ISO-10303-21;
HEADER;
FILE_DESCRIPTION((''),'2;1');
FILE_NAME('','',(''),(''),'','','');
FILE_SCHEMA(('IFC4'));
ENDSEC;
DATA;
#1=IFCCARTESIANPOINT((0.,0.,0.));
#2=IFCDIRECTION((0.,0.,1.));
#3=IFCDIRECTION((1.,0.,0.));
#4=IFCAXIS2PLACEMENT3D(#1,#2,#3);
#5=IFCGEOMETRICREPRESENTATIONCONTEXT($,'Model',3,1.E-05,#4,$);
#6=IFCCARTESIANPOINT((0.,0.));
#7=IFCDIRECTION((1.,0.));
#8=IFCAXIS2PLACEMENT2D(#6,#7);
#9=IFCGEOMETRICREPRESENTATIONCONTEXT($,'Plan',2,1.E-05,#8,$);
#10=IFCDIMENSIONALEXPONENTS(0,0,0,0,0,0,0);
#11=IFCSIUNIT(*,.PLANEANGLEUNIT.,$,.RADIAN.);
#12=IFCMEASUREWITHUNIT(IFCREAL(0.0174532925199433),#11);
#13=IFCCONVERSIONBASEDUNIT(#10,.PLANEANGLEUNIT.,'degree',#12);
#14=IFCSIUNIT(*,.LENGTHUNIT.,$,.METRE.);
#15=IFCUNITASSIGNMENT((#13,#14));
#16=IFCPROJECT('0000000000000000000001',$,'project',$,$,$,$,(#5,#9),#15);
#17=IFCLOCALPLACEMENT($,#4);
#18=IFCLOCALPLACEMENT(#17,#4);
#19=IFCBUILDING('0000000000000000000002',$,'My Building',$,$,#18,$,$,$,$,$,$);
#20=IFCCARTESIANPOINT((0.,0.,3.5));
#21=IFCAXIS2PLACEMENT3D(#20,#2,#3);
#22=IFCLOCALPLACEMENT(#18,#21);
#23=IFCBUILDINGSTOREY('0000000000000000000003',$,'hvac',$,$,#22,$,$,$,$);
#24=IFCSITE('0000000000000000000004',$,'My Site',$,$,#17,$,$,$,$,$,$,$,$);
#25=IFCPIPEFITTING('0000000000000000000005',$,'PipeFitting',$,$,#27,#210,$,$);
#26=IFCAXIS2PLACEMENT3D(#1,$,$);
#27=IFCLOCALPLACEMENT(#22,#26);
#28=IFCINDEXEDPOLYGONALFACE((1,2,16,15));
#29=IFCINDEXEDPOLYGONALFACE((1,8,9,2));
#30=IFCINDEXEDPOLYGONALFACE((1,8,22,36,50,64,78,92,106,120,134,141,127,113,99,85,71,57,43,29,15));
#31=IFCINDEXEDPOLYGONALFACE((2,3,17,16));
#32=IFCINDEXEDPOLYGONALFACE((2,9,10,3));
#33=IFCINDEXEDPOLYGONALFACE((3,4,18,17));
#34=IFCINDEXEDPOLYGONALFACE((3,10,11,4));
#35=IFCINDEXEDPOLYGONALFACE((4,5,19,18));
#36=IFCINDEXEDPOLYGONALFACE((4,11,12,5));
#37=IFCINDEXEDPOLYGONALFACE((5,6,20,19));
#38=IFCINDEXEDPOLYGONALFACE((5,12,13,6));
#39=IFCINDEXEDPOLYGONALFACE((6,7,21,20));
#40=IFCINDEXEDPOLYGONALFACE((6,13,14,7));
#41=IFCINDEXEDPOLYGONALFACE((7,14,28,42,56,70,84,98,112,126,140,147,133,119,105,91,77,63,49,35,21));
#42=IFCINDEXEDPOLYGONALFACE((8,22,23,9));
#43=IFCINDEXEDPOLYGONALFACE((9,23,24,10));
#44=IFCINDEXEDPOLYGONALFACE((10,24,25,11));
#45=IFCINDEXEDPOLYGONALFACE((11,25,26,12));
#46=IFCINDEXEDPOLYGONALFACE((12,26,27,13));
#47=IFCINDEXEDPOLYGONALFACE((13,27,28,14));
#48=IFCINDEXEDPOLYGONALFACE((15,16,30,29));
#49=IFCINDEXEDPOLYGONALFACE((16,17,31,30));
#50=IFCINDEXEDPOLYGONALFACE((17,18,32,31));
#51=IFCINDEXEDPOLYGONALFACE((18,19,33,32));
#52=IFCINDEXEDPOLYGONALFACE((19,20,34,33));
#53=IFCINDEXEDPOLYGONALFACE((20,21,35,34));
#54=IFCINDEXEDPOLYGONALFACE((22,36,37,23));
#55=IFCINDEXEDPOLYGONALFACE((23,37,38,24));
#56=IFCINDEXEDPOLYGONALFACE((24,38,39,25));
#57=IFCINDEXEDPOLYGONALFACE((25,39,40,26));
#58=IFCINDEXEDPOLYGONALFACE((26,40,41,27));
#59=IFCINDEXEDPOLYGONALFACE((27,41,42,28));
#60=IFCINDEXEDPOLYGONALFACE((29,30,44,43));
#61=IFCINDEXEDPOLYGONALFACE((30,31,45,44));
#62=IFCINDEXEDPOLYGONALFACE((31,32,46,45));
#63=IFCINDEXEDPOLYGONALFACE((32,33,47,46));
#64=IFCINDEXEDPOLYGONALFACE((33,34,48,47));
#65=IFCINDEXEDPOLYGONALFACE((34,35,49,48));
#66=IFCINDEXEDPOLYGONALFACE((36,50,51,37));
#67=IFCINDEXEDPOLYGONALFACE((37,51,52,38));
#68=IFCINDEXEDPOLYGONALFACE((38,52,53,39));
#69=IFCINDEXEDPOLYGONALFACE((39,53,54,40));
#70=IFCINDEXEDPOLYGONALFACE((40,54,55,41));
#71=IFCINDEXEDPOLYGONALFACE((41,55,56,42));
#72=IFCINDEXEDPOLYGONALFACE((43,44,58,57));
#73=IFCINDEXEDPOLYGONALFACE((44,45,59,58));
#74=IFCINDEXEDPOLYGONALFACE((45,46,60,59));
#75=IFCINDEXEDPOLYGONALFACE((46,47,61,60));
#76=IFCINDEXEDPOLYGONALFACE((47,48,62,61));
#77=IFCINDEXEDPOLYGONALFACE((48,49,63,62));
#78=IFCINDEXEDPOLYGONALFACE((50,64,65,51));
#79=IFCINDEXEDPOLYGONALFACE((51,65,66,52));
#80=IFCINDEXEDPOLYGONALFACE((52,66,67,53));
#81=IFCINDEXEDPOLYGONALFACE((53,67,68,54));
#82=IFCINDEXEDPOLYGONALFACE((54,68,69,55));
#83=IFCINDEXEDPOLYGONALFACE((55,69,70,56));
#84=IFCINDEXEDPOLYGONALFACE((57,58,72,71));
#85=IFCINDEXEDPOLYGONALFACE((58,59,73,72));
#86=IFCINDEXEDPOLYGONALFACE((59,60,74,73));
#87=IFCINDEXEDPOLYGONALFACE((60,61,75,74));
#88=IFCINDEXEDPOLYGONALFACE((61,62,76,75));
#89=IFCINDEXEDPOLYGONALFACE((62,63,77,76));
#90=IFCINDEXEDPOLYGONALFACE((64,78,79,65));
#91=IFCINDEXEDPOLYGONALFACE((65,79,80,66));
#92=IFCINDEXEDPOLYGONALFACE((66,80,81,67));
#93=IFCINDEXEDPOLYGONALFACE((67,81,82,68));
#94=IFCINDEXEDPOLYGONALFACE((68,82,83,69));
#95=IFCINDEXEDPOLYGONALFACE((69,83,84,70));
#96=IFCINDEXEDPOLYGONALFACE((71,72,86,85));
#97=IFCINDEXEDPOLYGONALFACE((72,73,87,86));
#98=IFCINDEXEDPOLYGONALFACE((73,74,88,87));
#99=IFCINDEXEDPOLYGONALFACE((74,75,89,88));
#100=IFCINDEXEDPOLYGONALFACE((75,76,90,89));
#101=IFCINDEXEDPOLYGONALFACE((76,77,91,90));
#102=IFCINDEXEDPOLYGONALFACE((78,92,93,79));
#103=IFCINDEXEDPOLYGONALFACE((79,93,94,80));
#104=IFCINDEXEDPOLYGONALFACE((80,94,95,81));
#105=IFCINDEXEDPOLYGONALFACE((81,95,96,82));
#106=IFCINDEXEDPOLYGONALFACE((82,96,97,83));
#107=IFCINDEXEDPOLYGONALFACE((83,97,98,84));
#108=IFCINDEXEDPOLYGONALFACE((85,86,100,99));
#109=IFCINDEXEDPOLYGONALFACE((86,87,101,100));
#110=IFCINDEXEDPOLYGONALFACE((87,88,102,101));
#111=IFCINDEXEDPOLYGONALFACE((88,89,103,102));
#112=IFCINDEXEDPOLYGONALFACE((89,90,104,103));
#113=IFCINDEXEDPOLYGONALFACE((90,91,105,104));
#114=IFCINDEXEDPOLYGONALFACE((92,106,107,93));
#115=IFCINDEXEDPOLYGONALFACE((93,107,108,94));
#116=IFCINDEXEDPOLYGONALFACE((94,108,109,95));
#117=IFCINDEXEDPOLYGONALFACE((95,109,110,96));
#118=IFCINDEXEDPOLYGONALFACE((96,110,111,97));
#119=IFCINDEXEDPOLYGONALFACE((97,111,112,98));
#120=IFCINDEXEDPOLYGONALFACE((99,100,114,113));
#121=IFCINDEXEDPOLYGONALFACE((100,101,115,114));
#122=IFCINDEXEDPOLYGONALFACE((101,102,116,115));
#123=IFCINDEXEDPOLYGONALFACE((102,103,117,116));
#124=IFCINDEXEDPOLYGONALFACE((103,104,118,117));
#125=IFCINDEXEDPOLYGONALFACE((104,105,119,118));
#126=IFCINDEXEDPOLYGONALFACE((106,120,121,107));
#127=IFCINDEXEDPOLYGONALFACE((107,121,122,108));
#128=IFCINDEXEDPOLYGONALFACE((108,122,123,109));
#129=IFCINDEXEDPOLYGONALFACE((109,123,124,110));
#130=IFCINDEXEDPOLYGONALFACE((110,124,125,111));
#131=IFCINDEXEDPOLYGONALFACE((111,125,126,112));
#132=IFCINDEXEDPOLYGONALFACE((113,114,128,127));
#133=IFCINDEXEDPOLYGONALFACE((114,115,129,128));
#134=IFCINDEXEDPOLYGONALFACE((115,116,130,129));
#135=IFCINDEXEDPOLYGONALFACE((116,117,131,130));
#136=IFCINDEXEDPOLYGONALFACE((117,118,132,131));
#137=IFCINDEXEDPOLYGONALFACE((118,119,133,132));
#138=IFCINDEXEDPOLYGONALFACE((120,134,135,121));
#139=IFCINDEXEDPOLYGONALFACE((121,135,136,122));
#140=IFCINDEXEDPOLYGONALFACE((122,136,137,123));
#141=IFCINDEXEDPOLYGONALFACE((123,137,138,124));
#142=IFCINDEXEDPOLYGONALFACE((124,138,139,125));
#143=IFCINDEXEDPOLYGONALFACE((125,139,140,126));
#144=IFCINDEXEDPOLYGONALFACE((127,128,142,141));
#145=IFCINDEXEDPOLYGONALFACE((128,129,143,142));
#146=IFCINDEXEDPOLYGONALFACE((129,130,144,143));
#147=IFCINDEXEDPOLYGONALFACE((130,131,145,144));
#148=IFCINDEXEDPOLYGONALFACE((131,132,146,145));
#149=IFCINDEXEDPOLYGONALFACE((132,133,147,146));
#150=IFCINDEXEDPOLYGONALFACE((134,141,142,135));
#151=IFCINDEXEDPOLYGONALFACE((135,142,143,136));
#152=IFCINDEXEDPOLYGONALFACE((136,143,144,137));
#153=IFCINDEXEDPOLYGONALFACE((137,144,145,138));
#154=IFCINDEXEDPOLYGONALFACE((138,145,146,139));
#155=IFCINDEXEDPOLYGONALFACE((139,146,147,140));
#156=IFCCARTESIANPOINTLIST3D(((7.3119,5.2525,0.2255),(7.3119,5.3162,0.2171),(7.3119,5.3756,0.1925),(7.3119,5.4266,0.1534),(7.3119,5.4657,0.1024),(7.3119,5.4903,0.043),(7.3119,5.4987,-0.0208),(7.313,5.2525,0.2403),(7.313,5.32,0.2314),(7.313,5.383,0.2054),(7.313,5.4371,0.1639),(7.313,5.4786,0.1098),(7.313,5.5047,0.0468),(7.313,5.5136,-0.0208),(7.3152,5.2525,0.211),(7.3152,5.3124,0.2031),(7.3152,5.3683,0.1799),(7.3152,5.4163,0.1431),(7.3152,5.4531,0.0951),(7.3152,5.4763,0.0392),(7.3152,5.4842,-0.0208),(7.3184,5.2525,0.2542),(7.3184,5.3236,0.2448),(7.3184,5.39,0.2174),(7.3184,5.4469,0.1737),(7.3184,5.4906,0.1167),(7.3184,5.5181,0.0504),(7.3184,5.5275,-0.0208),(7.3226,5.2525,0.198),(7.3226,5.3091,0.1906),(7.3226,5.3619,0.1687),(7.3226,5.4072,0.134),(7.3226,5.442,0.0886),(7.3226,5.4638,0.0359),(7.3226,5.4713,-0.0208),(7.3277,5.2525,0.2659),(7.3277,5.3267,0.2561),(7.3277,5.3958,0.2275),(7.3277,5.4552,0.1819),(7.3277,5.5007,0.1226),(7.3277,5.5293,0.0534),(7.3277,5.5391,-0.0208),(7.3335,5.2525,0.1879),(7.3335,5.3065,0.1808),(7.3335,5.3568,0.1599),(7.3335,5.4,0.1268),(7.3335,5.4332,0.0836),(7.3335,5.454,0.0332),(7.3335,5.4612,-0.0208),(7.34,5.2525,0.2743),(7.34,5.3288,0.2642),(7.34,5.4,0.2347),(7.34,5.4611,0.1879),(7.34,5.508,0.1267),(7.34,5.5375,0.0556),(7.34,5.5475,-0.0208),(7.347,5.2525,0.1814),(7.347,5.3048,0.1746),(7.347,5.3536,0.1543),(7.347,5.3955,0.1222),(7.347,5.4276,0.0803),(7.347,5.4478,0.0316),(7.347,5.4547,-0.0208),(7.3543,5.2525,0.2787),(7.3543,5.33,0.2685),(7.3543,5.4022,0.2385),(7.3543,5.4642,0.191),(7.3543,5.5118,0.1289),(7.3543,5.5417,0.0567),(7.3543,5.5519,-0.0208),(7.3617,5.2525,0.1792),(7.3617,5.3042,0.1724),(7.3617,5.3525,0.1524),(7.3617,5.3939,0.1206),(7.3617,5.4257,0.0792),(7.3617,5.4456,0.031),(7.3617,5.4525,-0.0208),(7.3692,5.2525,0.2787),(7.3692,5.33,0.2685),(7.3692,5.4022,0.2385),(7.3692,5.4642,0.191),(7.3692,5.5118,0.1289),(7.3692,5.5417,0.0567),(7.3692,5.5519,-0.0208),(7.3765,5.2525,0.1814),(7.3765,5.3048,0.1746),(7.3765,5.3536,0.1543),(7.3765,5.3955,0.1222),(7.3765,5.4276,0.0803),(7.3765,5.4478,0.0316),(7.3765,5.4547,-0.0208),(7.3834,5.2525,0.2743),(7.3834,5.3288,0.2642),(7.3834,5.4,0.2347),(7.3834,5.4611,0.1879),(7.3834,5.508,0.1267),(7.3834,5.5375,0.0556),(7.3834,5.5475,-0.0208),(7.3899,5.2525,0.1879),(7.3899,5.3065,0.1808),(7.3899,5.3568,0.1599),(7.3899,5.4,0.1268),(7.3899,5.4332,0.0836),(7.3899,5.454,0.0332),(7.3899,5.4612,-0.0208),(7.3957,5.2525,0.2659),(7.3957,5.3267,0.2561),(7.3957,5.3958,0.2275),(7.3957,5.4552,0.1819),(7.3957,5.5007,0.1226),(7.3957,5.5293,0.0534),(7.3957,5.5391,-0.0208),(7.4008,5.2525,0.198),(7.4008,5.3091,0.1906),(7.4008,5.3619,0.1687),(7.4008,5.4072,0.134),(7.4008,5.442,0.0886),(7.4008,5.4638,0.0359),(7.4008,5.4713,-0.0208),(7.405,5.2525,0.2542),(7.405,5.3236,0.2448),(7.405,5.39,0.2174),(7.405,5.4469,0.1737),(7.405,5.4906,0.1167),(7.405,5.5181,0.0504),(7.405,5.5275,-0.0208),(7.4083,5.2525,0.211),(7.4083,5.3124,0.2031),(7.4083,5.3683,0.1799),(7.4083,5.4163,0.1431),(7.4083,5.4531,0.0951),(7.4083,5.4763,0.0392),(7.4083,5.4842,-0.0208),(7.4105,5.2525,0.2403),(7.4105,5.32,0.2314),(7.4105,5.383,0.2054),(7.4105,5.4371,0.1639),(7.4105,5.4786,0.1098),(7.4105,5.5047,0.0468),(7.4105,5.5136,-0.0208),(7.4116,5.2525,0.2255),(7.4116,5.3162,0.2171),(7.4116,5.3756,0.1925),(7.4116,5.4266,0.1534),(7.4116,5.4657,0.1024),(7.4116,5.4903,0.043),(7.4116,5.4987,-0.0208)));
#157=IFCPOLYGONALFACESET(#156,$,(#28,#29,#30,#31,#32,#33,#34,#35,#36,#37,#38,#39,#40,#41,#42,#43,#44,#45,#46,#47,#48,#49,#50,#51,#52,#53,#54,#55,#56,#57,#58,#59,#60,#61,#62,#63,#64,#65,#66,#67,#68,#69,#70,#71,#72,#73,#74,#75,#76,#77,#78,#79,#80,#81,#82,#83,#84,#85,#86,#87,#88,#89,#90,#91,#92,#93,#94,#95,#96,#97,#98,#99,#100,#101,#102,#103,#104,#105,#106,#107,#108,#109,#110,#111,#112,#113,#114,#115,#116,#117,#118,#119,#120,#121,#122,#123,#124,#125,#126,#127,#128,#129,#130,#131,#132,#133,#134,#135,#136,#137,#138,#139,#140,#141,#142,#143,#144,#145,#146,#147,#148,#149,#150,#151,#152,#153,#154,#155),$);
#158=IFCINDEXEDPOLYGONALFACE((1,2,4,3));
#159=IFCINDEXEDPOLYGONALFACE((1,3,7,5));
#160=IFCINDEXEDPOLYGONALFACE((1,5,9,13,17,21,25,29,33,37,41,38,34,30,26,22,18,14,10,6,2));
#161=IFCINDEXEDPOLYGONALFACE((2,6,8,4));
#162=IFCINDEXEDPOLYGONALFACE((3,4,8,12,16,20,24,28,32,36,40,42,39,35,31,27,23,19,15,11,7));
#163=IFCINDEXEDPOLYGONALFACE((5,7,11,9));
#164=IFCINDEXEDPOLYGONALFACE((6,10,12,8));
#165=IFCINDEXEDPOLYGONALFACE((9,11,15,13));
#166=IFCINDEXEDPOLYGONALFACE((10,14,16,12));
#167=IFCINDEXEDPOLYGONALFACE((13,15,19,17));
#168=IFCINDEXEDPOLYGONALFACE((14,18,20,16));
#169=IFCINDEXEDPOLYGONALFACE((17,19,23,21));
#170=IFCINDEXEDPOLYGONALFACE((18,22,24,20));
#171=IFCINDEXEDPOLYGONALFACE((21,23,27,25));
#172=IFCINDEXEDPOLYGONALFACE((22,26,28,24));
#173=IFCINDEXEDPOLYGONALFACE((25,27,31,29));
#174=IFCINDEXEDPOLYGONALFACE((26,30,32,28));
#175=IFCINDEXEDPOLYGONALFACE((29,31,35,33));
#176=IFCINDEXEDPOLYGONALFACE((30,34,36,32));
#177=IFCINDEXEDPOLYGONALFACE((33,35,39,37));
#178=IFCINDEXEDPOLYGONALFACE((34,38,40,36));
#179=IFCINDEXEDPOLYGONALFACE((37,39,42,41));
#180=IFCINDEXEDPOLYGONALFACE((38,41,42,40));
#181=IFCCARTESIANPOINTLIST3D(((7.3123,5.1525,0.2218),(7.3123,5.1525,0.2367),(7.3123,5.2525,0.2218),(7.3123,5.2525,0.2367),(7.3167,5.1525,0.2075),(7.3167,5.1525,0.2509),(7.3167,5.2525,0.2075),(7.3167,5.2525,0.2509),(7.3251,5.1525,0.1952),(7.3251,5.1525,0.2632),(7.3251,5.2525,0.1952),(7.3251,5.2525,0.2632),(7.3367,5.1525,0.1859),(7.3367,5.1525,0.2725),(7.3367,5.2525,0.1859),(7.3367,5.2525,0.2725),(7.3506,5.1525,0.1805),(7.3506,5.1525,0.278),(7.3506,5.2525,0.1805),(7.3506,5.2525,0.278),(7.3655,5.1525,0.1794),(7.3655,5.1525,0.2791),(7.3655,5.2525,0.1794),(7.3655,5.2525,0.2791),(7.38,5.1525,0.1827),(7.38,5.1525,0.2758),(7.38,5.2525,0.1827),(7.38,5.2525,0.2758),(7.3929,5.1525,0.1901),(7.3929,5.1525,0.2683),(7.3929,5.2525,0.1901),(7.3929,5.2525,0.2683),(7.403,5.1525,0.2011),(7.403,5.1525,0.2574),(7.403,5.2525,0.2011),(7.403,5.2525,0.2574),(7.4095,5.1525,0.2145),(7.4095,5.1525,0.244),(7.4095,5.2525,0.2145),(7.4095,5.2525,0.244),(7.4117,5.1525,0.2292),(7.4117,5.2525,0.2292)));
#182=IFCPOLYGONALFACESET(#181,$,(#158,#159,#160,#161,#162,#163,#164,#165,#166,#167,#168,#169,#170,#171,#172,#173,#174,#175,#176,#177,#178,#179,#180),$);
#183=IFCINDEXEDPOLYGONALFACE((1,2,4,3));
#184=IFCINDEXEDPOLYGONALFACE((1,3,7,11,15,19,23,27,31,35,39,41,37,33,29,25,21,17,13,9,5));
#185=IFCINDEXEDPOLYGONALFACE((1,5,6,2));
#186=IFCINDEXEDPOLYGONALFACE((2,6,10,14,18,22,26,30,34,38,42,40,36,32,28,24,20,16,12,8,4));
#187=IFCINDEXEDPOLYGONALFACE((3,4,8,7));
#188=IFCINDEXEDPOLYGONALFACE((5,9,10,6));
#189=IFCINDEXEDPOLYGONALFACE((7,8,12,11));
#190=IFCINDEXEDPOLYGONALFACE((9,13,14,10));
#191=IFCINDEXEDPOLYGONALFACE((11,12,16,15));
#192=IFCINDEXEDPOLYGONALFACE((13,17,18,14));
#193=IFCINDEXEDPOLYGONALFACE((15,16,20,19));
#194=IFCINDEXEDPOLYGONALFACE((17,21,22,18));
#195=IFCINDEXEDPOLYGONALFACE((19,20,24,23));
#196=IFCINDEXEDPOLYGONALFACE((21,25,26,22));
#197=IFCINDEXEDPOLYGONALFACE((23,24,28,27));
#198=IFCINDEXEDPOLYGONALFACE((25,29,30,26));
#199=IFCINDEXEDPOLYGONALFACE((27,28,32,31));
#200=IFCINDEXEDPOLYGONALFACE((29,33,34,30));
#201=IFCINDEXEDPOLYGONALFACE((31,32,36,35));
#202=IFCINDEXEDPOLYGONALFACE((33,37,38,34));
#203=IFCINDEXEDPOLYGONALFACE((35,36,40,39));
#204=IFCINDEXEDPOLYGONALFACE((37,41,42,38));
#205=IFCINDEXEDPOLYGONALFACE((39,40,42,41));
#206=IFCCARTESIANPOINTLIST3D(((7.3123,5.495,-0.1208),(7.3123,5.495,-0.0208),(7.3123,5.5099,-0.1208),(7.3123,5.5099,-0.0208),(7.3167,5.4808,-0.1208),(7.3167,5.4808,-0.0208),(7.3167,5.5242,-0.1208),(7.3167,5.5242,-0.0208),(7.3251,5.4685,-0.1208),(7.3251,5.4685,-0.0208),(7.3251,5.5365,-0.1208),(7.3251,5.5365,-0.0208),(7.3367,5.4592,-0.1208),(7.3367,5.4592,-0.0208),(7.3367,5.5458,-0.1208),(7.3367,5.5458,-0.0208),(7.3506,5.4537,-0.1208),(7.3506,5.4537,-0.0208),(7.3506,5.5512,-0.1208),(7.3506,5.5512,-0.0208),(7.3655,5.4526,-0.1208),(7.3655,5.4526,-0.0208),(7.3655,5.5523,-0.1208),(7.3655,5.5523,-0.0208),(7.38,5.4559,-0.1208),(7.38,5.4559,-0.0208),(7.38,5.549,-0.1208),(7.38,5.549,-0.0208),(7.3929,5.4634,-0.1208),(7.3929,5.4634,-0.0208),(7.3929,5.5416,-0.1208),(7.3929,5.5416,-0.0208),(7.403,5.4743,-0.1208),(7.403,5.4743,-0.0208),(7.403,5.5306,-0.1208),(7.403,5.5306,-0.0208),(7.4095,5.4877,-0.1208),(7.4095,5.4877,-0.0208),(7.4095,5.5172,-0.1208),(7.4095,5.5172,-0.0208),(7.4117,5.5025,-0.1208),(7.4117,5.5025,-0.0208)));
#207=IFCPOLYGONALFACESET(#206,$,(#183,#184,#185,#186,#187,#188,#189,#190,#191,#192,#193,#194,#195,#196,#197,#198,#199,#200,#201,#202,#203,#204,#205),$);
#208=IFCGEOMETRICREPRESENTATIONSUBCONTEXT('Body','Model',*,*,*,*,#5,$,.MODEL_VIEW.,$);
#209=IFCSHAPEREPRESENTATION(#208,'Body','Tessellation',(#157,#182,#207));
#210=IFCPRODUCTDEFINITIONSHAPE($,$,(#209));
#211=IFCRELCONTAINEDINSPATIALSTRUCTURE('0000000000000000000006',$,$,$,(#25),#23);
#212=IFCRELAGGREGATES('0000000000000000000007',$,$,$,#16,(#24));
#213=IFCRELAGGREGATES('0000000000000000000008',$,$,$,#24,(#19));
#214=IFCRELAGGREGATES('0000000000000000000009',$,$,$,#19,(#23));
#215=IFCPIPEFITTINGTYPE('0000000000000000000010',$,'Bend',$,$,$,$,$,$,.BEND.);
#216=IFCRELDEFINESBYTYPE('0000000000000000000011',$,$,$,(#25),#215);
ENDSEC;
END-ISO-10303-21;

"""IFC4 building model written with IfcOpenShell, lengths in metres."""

from ifc_helpers import new_model, entity, si_unit, converted_unit, frame, origin_with_axes, origin_2d_with_axis, place, context, subcontext, project, spatial, circle, extrude, source, transform, mapped, type_object, type_shapes, element, save


model = new_model("IFC4")

# Units and contexts
model_context = context("Model", 3, precision=1e-05, world=origin_with_axes())
plan_context = context("Plan", 2, precision=1e-05, world=origin_2d_with_axis())
body_context_1 = subcontext(model_context, "Body", "Model", "MODEL_VIEW")
ifc_project = project(units=[converted_unit("PLANEANGLEUNIT", "degree", entity("IfcReal", 0.0174532925199433), si_unit("PLANEANGLEUNIT", "RADIAN"), dimensions=[0, 0, 0, 0, 0, 0, 0]), si_unit("LENGTHUNIT", "METRE")], contexts=[model_context, plan_context])

# Site, building, storey
site_placement = place(None, origin_with_axes())
site = spatial("IfcSite", under=ifc_project, at=site_placement, Name="My Site")
building_placement = place(site_placement, origin_with_axes())
building = spatial("IfcBuilding", under=site, at=building_placement, Name="My Building")
storey_placement = place(building_placement, frame((0.0, 0.0, 3.5), z_axis=(0.0, 0.0, 1.0), x_axis=(1.0, 0.0, 0.0)))
storey = spatial("IfcBuildingStorey", under=building, at=storey_placement, Name="hvac")

# Pipe fitting
pipe_fitting_type = type_object("IfcPipeFittingType", Name="Bend", PredefinedType="BEND")
shared_shape_1 = source(origin_with_axes(), body_context_1, "Body", "SolidModel", [
    entity("IfcSweptDiskSolid", entity("IfcIndexedPolyCurve", entity("IfcCartesianPointList3D", [[0.0, 0.0, -0.1], [0.0, -0.0732, -0.2768], [0.0, -0.25, -0.35]]), [entity("IfcArcIndex", [1, 2, 3])]), 0.05),
    extrude(circle(Radius=0.05), origin_with_axes(), (0.0, 0.0, -1.0), 0.1),
    extrude(circle(Radius=0.05), frame((0.0, -0.25, -0.35), z_axis=(0.0, -1.0, -0.000032), x_axis=(1.0, 0.0, 0.0)), (0.0, 0.0, 1.0), 0.1),
])
type_shapes(pipe_fitting_type, [shared_shape_1])
for number, where, z_axis, x_axis, name in (
    (1, (7.3617, 5.1525, 0.2292), (0.0, -1.0, 0.0), (1.0, 0.0, 0.0), "PipeFitting"),
):
    element("IfcPipeFitting", number, at=place(storey_placement, frame(where, z_axis=z_axis, x_axis=x_axis)), inside=storey, type_object=pipe_fitting_type, Name=name, context=body_context_1, shape_type="MappedRepresentation", body=[
        mapped(shared_shape_1, transform((0.0, 0.0, 0.0), x_axis=(1.0, 0.0, 0.0), y_axis=(0.0, 1.0, 0.0), z_axis=(0.0, 0.0, 1.0), scale=1.0)),
    ])

save(model, "model.ifc")
